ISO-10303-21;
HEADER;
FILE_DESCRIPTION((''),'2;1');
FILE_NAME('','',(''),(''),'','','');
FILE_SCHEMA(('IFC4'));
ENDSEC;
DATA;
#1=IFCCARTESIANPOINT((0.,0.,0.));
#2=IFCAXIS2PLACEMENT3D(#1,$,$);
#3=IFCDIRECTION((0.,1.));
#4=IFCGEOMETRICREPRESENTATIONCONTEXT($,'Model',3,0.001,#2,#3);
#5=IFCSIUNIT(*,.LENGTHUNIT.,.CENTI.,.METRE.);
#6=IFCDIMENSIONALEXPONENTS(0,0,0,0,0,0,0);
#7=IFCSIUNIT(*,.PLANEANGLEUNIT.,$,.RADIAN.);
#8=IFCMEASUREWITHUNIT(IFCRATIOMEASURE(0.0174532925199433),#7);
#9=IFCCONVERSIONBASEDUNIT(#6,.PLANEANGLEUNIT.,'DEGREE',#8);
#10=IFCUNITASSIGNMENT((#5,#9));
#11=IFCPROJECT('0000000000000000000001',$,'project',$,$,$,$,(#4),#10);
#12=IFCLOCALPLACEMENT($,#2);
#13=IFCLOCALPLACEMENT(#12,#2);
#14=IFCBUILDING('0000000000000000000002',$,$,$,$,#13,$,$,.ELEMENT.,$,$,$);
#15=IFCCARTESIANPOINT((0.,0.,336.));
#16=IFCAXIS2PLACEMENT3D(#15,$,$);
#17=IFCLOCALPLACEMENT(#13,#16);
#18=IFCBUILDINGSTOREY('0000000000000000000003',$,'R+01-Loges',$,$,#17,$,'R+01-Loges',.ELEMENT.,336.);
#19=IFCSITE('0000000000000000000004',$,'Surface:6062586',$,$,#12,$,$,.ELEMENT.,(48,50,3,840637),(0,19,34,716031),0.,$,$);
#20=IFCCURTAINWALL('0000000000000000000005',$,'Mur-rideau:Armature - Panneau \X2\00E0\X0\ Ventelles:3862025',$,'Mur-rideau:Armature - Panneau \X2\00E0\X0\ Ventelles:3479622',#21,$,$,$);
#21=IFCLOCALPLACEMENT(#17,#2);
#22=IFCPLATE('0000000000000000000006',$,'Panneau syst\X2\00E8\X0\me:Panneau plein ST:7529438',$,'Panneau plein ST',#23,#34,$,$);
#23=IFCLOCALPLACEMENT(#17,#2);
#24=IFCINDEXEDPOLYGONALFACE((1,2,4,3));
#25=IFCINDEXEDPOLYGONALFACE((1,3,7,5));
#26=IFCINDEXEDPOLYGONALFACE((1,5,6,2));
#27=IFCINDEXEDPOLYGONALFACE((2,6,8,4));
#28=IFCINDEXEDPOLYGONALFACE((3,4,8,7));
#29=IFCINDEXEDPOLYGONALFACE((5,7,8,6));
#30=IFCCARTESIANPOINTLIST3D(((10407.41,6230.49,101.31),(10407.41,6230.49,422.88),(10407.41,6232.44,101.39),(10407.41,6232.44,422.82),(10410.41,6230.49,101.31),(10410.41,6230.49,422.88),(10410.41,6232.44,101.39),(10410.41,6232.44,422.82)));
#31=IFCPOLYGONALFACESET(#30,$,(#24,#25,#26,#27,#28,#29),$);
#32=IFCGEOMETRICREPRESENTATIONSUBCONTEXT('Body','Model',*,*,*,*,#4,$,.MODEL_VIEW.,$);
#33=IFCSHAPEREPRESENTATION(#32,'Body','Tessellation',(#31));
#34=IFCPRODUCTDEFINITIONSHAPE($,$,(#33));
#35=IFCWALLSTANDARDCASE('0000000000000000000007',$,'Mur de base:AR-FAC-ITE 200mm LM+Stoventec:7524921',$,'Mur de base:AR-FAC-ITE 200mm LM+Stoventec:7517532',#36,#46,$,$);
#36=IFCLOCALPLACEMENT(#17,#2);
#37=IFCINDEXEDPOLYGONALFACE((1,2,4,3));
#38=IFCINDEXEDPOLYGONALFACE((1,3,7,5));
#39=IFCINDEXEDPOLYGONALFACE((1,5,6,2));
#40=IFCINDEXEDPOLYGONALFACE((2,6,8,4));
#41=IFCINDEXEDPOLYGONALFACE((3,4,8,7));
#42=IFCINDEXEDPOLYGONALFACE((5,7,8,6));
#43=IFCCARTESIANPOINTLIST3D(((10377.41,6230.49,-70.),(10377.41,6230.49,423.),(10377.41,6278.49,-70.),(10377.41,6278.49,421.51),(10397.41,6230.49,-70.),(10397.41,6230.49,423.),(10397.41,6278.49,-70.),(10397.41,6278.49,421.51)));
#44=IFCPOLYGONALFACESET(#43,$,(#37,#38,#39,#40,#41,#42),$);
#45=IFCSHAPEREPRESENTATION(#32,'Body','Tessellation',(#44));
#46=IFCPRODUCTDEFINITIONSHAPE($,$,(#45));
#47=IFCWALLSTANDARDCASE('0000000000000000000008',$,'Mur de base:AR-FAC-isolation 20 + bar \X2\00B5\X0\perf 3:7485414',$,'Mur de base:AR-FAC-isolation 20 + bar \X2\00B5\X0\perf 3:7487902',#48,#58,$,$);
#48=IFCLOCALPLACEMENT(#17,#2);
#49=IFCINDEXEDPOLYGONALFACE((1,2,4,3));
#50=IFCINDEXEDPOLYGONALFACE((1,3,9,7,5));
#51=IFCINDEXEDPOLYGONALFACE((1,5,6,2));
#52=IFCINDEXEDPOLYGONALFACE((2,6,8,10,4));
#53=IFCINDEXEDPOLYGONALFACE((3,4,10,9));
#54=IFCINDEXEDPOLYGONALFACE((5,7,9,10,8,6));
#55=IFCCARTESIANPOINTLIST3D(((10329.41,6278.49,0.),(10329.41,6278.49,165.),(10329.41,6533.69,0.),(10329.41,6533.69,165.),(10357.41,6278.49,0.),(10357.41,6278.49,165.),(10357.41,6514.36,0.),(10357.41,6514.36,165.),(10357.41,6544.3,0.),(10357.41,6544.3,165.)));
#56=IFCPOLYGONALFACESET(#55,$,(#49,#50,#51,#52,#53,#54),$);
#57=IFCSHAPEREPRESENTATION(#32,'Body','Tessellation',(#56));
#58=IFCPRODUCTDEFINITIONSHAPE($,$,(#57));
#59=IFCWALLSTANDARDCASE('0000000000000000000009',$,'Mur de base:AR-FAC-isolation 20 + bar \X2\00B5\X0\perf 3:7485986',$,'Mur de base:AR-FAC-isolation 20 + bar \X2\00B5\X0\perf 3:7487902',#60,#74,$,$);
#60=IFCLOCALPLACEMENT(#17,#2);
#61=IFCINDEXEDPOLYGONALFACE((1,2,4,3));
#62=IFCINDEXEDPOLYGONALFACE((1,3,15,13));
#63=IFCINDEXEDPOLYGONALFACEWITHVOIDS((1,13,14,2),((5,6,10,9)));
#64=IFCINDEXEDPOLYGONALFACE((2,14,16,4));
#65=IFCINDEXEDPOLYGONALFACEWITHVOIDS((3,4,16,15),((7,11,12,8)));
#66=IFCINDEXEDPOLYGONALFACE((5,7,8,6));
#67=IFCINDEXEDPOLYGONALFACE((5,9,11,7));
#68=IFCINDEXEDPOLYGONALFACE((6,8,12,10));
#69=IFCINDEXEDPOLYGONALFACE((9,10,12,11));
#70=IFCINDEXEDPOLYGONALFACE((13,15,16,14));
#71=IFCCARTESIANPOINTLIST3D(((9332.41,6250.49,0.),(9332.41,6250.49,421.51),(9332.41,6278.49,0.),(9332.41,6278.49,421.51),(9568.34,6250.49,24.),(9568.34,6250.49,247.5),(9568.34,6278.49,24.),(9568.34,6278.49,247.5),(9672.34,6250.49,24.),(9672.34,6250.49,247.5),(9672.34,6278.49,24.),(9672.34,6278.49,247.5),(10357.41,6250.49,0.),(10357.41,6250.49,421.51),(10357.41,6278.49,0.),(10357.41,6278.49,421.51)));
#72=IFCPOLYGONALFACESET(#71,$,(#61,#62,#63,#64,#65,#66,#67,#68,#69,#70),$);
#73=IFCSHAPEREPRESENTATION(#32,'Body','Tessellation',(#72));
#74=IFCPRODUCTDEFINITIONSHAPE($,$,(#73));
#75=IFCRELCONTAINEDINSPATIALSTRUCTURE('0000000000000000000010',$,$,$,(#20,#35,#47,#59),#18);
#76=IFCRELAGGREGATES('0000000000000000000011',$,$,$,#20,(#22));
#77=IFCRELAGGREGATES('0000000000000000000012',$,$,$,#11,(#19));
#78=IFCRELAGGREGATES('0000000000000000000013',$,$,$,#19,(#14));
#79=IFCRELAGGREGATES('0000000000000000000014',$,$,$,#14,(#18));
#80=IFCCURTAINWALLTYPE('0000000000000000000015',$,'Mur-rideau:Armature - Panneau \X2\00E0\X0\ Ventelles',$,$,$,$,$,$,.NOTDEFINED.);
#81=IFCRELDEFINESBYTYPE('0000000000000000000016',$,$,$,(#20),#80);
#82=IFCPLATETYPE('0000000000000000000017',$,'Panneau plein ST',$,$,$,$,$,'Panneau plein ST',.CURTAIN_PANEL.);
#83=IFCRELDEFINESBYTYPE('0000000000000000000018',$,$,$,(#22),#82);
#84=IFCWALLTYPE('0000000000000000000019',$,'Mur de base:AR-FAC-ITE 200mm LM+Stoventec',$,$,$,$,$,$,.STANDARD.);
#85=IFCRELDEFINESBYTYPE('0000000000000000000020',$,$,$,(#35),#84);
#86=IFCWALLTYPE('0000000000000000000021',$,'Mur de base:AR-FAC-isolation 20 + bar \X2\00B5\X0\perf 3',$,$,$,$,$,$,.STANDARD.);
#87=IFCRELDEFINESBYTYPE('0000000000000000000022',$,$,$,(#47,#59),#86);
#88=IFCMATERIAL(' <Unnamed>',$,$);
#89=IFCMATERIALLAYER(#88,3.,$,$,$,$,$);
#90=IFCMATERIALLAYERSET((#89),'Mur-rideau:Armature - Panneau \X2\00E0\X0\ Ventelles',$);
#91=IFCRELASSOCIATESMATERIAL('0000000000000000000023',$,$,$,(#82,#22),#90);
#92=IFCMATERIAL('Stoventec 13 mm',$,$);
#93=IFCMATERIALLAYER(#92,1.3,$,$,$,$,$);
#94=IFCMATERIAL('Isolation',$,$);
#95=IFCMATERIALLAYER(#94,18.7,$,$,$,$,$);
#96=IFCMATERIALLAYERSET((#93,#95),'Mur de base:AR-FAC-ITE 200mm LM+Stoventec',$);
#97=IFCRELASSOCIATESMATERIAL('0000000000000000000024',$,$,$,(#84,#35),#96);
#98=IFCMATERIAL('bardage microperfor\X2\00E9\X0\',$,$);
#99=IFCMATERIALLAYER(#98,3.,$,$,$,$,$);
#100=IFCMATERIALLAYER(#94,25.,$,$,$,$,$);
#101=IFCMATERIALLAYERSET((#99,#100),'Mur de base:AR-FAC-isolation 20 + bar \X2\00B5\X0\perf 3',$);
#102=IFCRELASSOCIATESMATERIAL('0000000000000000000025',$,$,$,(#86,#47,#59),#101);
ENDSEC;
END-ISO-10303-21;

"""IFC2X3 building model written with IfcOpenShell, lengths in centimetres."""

from ifc_helpers import new_model, entity, si_unit, converted_unit, direction, frame, frame_2d, origin, origin_2d_with_axis, place, context, subcontext, project, spatial, polyline, rectangle, outline, extrude, clip, bounded_halfspace, source, transform, mapped, material, layer, layer_set, layer_usage, type_object, type_shapes, element, aggregate, save


model = new_model("IFC2X3")

# Units and contexts
model_context = context("Model", 3, precision=0.001, world=origin(), true_north=direction((0.0, 1.0)))
body_context = subcontext(model_context, "Body", "Model", "MODEL_VIEW")
ifc_project = project(units=[si_unit("LENGTHUNIT", "METRE", prefix="CENTI"), converted_unit("PLANEANGLEUNIT", "DEGREE", entity("IfcRatioMeasure", 0.0174532925199433), si_unit("PLANEANGLEUNIT", "RADIAN"), dimensions=[0, 0, 0, 0, 0, 0, 0])], contexts=[model_context])

# Site, building, storey
site_placement = place(None, origin())
site = spatial("IfcSite", under=ifc_project, at=site_placement, Name="Surface:6062586", CompositionType="ELEMENT", RefLatitude=(48, 50, 3, 840637), RefLongitude=(0, 19, 34, 716031), RefElevation=0.0)
building_placement = place(site_placement, origin())
building = spatial("IfcBuilding", under=site, at=building_placement, CompositionType="ELEMENT")
storey_placement = place(building_placement, frame((0.0, 0.0, 336.0)))
storey = spatial("IfcBuildingStorey", under=building, at=storey_placement, Name="R+01-Loges", LongName="R+01-Loges", CompositionType="ELEMENT", Elevation=336.0)

# Curtain wall, plate
curtain_wall_type_1 = type_object("IfcCurtainWallType", Name="Mur-rideau:Armature - Panneau à Ventelles", PredefinedType="NOTDEFINED")
curtain_wall_1_placement = place(storey_placement, frame((0.0, 0.0, -336.0)))
curtain_wall_1 = element("IfcCurtainWall", 1, at=curtain_wall_1_placement, inside=storey, type_object=curtain_wall_type_1, Name="Mur-rideau:Armature - Panneau à Ventelles:3862025", ObjectType="Mur-rideau:Armature - Panneau à Ventelles:3479622")
ifc_material_1 = material(Name=" <Unnamed>")
ifc_layer_1 = layer(ifc_material_1, 3.0)
ifc_layer_set_1 = layer_set([ifc_layer_1], Name="Mur-rideau:Armature - Panneau à Ventelles")
ifc_layer_usage_1 = layer_usage(ifc_layer_set_1, "AXIS3", "POSITIVE", 0.05)
plate_type_1 = type_object("IfcPlateType", Name="Panneau plein ST", ElementType="Panneau plein ST", PredefinedType="CURTAIN_PANEL", material=ifc_layer_set_1)
shared_shape_1 = source(origin(), body_context, "Body", "SweptSolid", [
    extrude(outline(polyline([(-160.71, -0.97), (160.72, -0.97), (160.78, 0.97), (-160.79, 0.97), (-160.71, -0.97)])), frame((0.0, 0.0, 160.79), z_axis=(0.0, 1.0, 0.0), x_axis=(0.0, 0.0, 1.0)), (0.0, 0.0, 1.0), 3.0),
])
type_shapes(plate_type_1, [shared_shape_1])
plate_1_placement = place(curtain_wall_1_placement, frame((10407.41, 6231.47, 437.31), z_axis=(0.0, 0.0, 1.0), x_axis=(0.0, -1.0, 0.0)))
plate_1 = element("IfcPlate", 2, at=plate_1_placement, type_object=plate_type_1, material=ifc_layer_usage_1, Name="Panneau système:Panneau plein ST:7529438", ObjectType="Panneau plein ST", context=body_context, shape_type="MappedRepresentation", body=[
    mapped(shared_shape_1, transform((0.0, 0.0, 0.0), scale=1.0)),
])
aggregate(curtain_wall_1, [plate_1])

# Walls
ifc_material_2 = material(Name="Stoventec 13 mm")
ifc_layer_2 = layer(ifc_material_2, 1.3)
ifc_material_3 = material(Name="Isolation")
ifc_layer_3 = layer(ifc_material_3, 18.7)
ifc_layer_set_2 = layer_set([ifc_layer_2, ifc_layer_3], Name="Mur de base:AR-FAC-ITE 200mm LM+Stoventec")
ifc_layer_usage_2 = layer_usage(ifc_layer_set_2, "AXIS2", "POSITIVE", -10.0)
wall_type_1 = type_object("IfcWallType", Name="Mur de base:AR-FAC-ITE 200mm LM+Stoventec", PredefinedType="STANDARD", material=ifc_layer_set_2)
wall_1_placement = place(storey_placement, frame((10387.41, 6230.49, -70.0), z_axis=(0.0, 0.0, 1.0), x_axis=(0.0, 1.0, 0.0)))
element("IfcWallStandardCase", 3, at=wall_1_placement, inside=storey, type_object=wall_type_1, material=ifc_layer_usage_2, Name="Mur de base:AR-FAC-ITE 200mm LM+Stoventec:7524921", ObjectType="Mur de base:AR-FAC-ITE 200mm LM+Stoventec:7517532", context=body_context, shape_type="Clipping", body=[
    clip(extrude(rectangle(XDim=48.0, YDim=20.0, at=frame_2d((24.0, 0.0), x_axis=(-1.0, 0.0))), origin(), (0.0, 0.0, 1.0), 493.0), bounded_halfspace(frame((0.0, -10.0, 493.0), z_axis=(0.030985, 0.0, 0.99952), x_axis=(0.0, -1.0, 0.0)), False, frame((0.0, -10.0, 493.0)), polyline([(0.0, 0.0), (48.0, 0.0), (48.0, 20.0), (0.0, 20.0), (0.0, 0.0)]))),
])
ifc_material_4 = material(Name="bardage microperforé")
ifc_layer_4 = layer(ifc_material_4, 3.0)
ifc_layer_5 = layer(ifc_material_3, 25.0)
ifc_layer_set_3 = layer_set([ifc_layer_4, ifc_layer_5], Name="Mur de base:AR-FAC-isolation 20 + bar µperf 3")
ifc_layer_usage_3 = layer_usage(ifc_layer_set_3, "AXIS2", "NEGATIVE", 14.0)
wall_type_2 = type_object("IfcWallType", Name="Mur de base:AR-FAC-isolation 20 + bar µperf 3", PredefinedType="STANDARD", material=ifc_layer_set_3)
wall_2_placement = place(storey_placement, frame((10343.41, 6278.49, 0.0), z_axis=(0.0, 0.0, 1.0), x_axis=(0.0, 1.0, 0.0)))
element("IfcWallStandardCase", 4, at=wall_2_placement, inside=storey, type_object=wall_type_2, material=ifc_layer_usage_3, Name="Mur de base:AR-FAC-isolation 20 + bar µperf 3:7485414", ObjectType="Mur de base:AR-FAC-isolation 20 + bar µperf 3:7487902", context=body_context, shape_type="SweptSolid", body=[
    extrude(outline(polyline([(265.81, -14.0), (255.2, 14.0), (0.0, 14.0), (0.0, -14.0), (235.86, -14.0), (265.81, -14.0)])), origin(), (0.0, 0.0, 1.0), 165.0),
])

# Wall, opening
ifc_layer_usage_4 = layer_usage(ifc_layer_set_3, "AXIS2", "POSITIVE", -14.0)
wall_3_placement = place(storey_placement, frame((10357.41, 6264.49, 0.0), z_axis=(0.0, 0.0, 1.0), x_axis=(-1.0, 0.0, 0.0)))
wall_3 = element("IfcWallStandardCase", 5, at=wall_3_placement, inside=storey, type_object=wall_type_2, material=ifc_layer_usage_4, Name="Mur de base:AR-FAC-isolation 20 + bar µperf 3:7485986", ObjectType="Mur de base:AR-FAC-isolation 20 + bar µperf 3:7487902", context=body_context, shape_type="SweptSolid", body=[
    extrude(rectangle(XDim=1025.0, YDim=28.0, at=frame_2d((512.5, 0.0), x_axis=(-1.0, 0.0))), origin(), (0.0, 0.0, 1.0), 421.51),
])
opening_placement = place(wall_3_placement, frame((789.07, 186.4, 24.0)))
element("IfcOpeningElement", 6, at=opening_placement, cuts=wall_3, ObjectType="Opening", context=body_context, shape_type="SweptSolid", body=[
    extrude(rectangle(XDim=223.5, YDim=104.0, at=origin_2d_with_axis()), frame((-52.0, -304.8, 111.75), z_axis=(0.0, 1.0, 0.0), x_axis=(0.0, 0.0, 1.0)), (0.0, 0.0, 1.0), 304.8),
])

save(model, "model.ifc")
